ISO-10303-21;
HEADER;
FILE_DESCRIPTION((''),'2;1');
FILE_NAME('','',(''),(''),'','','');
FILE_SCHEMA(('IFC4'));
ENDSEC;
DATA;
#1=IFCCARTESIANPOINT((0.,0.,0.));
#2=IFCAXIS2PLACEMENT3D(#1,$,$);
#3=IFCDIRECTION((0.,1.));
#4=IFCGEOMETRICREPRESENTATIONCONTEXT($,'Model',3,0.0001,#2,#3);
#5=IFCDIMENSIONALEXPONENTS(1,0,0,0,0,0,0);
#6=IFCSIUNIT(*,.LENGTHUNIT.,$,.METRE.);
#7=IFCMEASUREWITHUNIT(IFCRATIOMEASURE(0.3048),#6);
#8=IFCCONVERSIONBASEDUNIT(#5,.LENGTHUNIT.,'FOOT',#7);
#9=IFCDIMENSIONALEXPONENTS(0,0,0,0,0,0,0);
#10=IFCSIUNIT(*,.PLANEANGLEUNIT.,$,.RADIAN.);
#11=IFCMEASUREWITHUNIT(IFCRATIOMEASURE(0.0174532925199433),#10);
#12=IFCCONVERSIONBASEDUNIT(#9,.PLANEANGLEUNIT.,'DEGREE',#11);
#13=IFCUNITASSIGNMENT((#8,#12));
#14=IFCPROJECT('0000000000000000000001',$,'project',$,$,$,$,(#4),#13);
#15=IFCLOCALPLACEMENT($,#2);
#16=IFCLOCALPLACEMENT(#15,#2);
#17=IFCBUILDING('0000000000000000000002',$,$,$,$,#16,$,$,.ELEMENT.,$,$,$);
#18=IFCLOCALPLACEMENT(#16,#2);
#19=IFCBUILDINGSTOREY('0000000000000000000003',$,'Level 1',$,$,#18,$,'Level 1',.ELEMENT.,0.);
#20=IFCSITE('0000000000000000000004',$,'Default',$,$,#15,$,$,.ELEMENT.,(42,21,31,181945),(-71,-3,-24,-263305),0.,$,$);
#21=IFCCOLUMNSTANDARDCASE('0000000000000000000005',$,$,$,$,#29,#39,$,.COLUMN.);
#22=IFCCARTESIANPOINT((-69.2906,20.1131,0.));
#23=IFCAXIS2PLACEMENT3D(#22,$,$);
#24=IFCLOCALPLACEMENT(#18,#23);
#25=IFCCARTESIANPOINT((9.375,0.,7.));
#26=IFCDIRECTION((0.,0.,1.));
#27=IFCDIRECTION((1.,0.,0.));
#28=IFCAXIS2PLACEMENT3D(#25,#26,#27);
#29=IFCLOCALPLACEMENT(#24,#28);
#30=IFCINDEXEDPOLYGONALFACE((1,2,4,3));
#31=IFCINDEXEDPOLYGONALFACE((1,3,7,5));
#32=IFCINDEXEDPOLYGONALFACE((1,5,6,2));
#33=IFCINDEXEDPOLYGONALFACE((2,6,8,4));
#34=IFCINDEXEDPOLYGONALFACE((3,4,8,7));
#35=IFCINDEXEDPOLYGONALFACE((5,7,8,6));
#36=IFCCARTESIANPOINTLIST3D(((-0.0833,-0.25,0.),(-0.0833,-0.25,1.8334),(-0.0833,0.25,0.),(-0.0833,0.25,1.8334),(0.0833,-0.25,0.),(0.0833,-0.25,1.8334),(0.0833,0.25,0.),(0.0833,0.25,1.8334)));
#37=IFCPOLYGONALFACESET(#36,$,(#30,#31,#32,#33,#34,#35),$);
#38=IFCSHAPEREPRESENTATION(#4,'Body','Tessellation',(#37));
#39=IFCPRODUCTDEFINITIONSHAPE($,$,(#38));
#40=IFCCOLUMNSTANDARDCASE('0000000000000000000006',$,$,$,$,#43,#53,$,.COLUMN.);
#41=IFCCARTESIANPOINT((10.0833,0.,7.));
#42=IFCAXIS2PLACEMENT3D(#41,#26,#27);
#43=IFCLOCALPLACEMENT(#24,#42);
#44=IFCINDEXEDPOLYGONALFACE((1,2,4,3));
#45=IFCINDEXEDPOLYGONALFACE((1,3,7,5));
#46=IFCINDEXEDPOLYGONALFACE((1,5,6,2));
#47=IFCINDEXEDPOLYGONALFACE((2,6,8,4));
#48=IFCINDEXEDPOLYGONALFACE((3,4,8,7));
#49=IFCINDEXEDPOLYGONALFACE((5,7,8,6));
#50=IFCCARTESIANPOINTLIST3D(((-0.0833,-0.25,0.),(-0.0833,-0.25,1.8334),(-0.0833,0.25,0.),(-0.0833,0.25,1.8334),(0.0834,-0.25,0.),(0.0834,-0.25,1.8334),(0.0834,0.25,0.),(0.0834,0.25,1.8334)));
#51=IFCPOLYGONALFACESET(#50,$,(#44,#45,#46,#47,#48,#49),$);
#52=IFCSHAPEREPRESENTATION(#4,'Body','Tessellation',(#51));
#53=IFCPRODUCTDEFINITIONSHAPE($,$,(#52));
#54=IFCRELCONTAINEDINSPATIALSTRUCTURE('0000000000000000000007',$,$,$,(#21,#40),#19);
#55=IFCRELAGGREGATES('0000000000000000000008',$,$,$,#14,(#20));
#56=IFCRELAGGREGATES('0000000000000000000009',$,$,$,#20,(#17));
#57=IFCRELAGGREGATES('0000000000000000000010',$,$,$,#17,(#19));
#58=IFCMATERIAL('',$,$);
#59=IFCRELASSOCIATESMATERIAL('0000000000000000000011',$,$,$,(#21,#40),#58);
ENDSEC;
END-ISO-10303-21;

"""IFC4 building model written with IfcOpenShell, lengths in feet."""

from ifc_helpers import new_model, entity, si_unit, converted_unit, direction, frame, origin, place, context, project, spatial, rectangle, extrude, material, element, save


model = new_model("IFC4")

# Units and contexts
model_context = context("Model", 3, precision=0.0001, world=origin(), true_north=direction((0.0, 1.0)))
ifc_project = project(units=[converted_unit("LENGTHUNIT", "FOOT", entity("IfcRatioMeasure", 0.3048), si_unit("LENGTHUNIT", "METRE"), dimensions=[1, 0, 0, 0, 0, 0, 0]), converted_unit("PLANEANGLEUNIT", "DEGREE", entity("IfcRatioMeasure", 0.0174532925199433), si_unit("PLANEANGLEUNIT", "RADIAN"), dimensions=[0, 0, 0, 0, 0, 0, 0])], contexts=[model_context])

# Site, building, storey
site_placement = place(None, origin())
site = spatial("IfcSite", under=ifc_project, at=site_placement, Name="Default", CompositionType="ELEMENT", RefLatitude=(42, 21, 31, 181945), RefLongitude=(-71, -3, -24, -263305), RefElevation=0.0)
building_placement = place(site_placement, origin())
building = spatial("IfcBuilding", under=site, at=building_placement, CompositionType="ELEMENT")
storey_placement = place(building_placement, origin())
storey = spatial("IfcBuildingStorey", under=building, at=storey_placement, Name="Level 1", LongName="Level 1", CompositionType="ELEMENT", Elevation=0.0)

# Columns
placement_1 = place(storey_placement, frame((-69.2906, 20.1131, 0.0)))
ifc_material_1 = material(Name="")
for number, where, z_axis, x_axis in (
    (1, (9.375, 0.0, 7.0), (0.0, 0.0, 1.0), (1.0, 0.0, 0.0)),
    (2, (10.0833, 0.0, 7.0), (0.0, 0.0, 1.0), (1.0, 0.0, 0.0)),
):
    element("IfcColumnStandardCase", number, at=place(placement_1, frame(where, z_axis=z_axis, x_axis=x_axis)), inside=storey, material=ifc_material_1, PredefinedType="COLUMN", context=model_context, shape_type="SweptSolid", body=[
        extrude(rectangle(XDim=0.1667, YDim=0.5), origin(), (0.0, 0.0, 1.0), 1.8334),
    ])

save(model, "model.ifc")
